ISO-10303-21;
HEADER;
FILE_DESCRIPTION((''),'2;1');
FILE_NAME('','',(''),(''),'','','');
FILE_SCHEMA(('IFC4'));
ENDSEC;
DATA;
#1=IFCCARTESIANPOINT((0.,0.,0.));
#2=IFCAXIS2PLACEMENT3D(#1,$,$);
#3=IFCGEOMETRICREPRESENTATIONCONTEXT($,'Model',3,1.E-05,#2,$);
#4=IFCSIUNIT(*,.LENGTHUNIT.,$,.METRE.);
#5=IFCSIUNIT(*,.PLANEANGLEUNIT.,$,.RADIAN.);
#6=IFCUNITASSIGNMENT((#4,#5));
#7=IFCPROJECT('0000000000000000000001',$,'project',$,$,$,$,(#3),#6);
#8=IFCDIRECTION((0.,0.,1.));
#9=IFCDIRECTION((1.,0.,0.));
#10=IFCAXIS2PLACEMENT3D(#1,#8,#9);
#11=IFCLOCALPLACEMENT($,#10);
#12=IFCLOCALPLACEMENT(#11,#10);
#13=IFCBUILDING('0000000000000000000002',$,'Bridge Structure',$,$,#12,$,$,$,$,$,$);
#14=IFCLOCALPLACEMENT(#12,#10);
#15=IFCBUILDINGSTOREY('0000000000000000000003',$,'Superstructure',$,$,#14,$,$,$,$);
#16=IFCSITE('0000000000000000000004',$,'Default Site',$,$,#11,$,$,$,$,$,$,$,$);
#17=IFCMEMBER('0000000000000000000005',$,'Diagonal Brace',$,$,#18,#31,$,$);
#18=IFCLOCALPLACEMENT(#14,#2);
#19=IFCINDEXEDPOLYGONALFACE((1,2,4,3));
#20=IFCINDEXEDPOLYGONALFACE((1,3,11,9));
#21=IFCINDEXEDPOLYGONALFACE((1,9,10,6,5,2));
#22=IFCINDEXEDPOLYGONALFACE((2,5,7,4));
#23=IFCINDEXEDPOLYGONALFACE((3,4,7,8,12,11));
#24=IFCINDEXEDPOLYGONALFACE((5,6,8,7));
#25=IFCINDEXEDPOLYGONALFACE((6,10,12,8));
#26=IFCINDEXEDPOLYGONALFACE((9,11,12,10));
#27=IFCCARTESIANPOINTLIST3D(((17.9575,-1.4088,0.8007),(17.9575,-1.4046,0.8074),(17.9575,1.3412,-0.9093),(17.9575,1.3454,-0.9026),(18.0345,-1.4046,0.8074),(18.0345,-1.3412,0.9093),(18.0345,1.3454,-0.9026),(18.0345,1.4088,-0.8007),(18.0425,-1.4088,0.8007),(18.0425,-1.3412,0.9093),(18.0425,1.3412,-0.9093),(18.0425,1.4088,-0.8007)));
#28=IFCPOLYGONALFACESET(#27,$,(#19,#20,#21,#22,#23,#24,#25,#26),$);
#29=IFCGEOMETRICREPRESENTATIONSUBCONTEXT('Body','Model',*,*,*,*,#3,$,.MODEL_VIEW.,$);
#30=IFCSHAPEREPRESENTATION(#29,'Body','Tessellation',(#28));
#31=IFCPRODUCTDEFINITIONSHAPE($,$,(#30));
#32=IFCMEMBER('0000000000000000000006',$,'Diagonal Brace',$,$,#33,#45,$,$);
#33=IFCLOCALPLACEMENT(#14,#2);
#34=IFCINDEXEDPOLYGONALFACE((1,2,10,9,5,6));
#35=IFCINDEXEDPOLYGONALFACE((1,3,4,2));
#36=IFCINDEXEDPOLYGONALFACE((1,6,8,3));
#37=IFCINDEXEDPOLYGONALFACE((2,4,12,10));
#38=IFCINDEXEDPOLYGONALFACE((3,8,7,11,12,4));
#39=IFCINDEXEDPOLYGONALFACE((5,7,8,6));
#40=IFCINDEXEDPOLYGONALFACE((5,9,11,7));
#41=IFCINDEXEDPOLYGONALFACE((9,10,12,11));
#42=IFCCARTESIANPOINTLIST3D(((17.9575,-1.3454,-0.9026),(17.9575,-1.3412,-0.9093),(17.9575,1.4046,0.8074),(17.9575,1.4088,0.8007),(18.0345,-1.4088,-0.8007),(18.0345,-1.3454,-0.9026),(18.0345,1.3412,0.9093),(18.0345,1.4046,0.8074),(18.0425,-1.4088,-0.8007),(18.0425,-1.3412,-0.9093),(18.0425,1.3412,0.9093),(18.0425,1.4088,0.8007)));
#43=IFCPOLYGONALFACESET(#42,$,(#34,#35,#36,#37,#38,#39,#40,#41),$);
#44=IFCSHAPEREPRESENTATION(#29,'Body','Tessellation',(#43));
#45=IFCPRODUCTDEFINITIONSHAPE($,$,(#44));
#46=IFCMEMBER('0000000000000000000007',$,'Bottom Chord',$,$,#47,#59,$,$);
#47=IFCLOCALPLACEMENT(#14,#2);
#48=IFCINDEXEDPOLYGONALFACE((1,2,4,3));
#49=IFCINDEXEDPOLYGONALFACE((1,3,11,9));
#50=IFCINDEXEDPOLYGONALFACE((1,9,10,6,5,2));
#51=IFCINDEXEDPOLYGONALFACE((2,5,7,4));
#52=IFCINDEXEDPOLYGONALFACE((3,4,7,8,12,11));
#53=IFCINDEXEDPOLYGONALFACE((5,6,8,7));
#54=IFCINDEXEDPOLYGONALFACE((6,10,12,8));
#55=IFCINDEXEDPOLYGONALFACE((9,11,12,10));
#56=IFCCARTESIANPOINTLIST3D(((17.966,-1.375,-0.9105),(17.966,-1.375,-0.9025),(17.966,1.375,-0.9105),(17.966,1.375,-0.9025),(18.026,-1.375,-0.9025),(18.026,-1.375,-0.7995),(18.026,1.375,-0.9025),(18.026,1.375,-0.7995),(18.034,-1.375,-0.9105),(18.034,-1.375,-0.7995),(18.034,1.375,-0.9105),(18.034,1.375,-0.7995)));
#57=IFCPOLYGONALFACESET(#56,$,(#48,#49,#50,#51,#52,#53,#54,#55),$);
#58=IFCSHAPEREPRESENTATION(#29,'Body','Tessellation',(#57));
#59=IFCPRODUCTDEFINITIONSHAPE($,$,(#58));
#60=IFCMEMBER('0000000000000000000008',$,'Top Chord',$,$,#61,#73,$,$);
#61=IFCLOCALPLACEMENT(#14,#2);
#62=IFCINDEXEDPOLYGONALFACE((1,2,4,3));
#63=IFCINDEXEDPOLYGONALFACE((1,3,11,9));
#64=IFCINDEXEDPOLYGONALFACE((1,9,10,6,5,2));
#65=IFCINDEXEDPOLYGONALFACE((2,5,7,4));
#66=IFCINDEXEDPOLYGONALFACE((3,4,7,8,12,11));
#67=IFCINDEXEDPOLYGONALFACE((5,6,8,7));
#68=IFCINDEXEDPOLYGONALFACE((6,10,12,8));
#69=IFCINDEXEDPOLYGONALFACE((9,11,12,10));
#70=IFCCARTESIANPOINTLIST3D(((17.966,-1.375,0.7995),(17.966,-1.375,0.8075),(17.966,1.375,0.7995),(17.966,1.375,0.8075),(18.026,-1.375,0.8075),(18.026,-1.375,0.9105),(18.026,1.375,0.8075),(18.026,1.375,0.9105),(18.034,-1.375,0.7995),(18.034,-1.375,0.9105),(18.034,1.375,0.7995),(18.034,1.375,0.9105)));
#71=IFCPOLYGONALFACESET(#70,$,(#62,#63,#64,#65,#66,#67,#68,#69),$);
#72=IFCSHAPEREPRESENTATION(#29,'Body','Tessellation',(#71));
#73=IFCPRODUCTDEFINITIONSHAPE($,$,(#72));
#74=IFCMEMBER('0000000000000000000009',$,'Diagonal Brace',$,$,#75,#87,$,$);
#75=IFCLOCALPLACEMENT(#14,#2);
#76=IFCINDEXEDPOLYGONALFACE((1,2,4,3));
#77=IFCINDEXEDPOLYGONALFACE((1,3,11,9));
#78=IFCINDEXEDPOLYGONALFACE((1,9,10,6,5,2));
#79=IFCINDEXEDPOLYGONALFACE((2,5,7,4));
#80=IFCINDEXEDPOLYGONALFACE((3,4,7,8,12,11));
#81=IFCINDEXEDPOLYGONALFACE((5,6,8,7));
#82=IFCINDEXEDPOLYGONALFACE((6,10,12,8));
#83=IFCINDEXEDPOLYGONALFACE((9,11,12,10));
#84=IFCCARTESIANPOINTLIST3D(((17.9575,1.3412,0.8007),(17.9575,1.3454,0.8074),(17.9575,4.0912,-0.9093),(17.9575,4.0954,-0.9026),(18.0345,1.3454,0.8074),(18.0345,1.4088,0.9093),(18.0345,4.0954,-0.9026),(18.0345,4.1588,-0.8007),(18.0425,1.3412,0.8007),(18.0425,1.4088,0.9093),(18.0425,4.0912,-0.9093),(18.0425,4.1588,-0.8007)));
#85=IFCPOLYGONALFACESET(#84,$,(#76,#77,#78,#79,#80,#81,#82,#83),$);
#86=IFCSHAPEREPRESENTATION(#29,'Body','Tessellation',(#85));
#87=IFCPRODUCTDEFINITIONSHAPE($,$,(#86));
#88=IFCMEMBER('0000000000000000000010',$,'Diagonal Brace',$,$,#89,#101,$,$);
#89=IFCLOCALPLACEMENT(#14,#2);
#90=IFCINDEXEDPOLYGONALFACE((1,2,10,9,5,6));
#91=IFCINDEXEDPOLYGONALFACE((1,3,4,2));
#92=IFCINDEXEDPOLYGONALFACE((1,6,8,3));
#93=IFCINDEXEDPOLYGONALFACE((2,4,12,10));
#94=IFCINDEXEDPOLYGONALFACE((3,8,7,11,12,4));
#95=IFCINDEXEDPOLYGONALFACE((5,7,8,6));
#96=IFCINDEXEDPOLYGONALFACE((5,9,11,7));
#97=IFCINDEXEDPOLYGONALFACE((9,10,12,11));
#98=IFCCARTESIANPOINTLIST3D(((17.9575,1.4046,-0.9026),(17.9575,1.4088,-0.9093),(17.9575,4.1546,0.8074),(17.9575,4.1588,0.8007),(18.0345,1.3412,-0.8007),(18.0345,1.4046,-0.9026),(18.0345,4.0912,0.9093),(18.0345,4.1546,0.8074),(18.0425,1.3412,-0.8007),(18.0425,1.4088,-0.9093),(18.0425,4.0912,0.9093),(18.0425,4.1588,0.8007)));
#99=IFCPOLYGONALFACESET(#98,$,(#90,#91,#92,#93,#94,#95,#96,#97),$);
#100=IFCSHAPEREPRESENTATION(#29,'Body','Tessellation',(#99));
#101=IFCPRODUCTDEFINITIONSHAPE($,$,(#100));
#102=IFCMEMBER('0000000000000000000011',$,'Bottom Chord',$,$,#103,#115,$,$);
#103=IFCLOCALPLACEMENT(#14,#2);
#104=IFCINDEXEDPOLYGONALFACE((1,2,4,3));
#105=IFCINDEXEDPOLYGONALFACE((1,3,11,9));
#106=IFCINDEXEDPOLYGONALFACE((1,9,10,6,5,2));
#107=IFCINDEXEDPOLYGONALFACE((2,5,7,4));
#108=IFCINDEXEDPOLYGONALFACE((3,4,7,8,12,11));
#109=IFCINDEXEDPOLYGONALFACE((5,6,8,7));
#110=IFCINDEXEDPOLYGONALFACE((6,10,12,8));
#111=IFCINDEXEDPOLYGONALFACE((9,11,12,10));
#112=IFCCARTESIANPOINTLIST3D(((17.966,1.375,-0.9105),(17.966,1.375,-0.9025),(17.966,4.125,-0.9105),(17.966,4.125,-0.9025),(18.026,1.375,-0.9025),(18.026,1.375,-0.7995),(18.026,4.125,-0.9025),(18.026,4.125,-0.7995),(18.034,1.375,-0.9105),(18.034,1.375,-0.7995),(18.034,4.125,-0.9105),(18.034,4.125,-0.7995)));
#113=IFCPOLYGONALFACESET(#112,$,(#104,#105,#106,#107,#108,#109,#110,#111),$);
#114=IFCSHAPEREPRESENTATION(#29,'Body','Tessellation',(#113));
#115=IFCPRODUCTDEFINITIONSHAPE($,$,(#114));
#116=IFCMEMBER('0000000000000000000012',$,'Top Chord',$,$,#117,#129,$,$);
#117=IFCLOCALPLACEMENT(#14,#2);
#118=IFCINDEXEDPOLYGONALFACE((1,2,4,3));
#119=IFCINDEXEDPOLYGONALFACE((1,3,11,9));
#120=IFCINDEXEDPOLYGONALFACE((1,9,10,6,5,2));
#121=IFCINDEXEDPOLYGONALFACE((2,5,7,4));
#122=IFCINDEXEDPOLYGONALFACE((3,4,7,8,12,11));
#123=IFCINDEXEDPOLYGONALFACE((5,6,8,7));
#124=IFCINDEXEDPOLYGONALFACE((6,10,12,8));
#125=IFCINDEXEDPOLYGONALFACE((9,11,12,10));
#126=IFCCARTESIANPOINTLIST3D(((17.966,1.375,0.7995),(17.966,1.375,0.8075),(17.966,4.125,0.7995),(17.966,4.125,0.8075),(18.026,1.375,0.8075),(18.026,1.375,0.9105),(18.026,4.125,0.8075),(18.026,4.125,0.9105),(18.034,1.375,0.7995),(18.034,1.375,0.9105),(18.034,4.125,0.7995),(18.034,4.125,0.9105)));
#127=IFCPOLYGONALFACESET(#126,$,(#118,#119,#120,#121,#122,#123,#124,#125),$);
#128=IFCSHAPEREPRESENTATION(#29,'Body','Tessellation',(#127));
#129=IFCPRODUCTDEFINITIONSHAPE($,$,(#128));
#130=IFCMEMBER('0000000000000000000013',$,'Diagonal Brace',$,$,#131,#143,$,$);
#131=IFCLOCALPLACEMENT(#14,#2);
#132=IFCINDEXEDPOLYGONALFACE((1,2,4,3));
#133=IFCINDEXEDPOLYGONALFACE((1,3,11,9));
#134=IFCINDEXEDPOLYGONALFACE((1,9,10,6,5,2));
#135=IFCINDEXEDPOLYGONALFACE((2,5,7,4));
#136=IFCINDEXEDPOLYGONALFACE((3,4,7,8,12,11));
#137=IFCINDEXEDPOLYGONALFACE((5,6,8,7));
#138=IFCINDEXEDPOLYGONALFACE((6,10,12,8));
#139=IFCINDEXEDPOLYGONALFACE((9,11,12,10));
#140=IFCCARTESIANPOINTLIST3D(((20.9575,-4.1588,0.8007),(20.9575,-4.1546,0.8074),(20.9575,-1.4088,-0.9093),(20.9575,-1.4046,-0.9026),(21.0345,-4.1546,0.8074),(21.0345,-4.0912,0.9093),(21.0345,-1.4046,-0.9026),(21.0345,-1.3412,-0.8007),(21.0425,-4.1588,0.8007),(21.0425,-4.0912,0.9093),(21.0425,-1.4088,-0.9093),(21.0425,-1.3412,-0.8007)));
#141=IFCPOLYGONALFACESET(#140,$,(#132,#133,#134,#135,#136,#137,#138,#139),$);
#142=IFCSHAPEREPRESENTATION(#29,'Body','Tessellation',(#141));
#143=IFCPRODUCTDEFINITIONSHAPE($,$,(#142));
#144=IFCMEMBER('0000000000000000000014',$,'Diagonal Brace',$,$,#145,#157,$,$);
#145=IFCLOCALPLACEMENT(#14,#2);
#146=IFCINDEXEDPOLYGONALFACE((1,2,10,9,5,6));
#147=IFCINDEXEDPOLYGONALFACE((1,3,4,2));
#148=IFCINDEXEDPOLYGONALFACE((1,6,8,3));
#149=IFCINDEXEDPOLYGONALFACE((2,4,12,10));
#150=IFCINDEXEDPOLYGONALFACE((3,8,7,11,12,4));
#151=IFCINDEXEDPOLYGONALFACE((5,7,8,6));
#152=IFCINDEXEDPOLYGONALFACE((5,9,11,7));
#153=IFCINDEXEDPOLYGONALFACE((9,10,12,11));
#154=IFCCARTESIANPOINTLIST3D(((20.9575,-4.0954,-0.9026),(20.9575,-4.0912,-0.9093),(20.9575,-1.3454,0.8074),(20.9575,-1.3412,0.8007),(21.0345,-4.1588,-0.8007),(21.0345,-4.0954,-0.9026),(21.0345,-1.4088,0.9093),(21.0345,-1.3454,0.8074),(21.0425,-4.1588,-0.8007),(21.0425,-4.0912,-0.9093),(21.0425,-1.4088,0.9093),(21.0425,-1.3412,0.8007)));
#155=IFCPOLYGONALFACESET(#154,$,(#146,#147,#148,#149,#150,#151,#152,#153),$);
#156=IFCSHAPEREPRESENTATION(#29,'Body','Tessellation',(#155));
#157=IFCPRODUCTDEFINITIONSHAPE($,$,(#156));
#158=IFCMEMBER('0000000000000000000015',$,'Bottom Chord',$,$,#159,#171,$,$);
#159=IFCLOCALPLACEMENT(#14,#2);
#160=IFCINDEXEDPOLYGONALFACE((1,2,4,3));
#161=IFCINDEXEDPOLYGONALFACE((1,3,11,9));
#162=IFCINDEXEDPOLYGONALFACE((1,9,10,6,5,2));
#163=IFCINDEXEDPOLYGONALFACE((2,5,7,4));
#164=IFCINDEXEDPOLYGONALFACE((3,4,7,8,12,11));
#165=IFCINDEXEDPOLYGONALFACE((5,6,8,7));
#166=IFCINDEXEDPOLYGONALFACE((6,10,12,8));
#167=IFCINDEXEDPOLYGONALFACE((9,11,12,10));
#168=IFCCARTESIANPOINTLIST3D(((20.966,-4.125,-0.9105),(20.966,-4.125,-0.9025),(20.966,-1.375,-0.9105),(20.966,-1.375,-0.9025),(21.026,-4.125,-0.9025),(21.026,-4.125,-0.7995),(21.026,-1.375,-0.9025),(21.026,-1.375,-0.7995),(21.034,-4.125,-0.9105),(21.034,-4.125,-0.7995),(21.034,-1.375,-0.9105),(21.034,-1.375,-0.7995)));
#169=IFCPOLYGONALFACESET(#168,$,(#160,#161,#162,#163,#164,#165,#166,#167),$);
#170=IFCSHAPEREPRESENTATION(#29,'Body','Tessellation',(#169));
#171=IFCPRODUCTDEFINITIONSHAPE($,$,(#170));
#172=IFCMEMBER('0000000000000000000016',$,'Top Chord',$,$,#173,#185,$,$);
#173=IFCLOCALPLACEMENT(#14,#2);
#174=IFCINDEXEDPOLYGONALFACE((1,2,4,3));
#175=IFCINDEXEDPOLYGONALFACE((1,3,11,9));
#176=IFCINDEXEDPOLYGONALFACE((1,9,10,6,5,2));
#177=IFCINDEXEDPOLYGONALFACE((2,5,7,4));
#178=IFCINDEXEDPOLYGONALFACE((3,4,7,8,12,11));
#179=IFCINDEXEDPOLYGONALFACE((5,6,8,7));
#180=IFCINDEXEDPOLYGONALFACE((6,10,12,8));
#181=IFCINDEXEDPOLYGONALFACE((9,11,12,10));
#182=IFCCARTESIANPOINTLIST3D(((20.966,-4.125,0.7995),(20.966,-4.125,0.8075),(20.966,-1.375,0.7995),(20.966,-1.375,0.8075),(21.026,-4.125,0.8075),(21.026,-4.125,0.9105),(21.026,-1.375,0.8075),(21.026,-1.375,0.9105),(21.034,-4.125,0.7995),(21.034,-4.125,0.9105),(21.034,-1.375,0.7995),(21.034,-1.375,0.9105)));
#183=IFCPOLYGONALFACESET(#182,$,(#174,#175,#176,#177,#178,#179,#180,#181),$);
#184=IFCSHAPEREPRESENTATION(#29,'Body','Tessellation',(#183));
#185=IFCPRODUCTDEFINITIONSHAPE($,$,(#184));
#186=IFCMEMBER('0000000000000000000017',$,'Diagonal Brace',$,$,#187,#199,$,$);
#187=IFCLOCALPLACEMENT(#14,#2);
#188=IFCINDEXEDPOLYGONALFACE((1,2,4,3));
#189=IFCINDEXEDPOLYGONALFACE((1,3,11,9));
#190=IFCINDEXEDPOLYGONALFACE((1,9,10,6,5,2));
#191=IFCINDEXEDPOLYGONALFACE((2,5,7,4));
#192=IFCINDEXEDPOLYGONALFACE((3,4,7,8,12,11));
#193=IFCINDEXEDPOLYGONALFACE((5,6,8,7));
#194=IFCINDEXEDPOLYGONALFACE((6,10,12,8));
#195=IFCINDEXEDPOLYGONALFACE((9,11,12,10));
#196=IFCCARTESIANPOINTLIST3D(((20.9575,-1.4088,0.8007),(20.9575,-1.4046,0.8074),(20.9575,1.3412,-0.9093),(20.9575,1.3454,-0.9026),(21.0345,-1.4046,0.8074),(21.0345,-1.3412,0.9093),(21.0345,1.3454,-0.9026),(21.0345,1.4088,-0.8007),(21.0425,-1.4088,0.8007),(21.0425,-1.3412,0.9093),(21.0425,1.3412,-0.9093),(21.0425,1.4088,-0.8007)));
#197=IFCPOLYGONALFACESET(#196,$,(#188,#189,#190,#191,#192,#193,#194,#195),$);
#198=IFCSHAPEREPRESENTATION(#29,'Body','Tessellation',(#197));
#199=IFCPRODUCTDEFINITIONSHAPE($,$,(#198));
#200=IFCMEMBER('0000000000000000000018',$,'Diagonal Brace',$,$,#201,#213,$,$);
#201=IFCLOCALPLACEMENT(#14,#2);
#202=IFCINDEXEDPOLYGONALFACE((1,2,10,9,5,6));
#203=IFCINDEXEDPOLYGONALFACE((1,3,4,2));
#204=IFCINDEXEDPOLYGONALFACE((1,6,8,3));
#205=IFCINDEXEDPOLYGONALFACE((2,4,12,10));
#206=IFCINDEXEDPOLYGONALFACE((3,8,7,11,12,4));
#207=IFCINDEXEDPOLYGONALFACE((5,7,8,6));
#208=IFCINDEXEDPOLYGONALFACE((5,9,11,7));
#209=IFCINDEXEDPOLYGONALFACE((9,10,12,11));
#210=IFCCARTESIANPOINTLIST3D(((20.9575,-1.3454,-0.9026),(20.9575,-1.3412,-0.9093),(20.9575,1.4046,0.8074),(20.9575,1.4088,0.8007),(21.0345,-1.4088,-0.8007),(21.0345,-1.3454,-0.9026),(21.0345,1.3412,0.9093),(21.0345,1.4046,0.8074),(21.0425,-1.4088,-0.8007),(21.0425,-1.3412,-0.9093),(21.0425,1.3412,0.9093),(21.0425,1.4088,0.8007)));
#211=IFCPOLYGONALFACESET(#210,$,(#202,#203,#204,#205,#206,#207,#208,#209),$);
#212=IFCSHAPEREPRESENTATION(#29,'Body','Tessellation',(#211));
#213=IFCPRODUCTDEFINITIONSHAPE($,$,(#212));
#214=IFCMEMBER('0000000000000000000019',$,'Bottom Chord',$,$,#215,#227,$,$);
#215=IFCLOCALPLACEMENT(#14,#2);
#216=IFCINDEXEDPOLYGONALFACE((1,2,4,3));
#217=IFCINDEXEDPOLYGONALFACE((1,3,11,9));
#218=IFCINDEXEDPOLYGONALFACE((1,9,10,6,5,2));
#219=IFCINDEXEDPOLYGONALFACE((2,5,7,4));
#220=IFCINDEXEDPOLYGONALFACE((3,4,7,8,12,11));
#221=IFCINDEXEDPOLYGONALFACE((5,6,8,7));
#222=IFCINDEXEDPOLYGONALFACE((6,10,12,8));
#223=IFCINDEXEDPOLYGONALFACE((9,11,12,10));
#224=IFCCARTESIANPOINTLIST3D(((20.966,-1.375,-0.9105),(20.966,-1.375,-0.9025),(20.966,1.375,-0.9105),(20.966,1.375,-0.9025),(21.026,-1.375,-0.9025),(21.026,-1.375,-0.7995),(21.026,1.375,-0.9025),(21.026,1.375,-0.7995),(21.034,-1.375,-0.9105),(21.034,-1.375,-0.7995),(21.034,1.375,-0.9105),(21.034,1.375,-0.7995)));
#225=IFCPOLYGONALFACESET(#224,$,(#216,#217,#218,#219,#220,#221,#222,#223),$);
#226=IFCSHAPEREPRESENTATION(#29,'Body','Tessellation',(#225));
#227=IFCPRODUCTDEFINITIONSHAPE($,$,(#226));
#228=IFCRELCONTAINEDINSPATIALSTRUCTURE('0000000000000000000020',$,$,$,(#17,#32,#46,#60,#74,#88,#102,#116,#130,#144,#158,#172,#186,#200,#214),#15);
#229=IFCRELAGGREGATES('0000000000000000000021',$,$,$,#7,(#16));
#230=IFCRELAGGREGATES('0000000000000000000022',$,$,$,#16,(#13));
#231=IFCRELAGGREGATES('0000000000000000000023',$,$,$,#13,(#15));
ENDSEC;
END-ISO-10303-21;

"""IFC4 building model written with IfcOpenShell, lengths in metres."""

from ifc_helpers import new_model, si_unit, frame, origin, origin_with_axes, origin_2d_with_axis, place, context, subcontext, project, spatial, l_section, extrude, element, save


model = new_model("IFC4")

# Units and contexts
model_context = context("Model", 3, precision=1e-05, world=origin())
body_context = subcontext(model_context, "Body", "Model", "MODEL_VIEW")
ifc_project = project(units=[si_unit("LENGTHUNIT", "METRE"), si_unit("PLANEANGLEUNIT", "RADIAN")], contexts=[model_context])

# Site, building, storey
site_placement = place(None, origin_with_axes())
site = spatial("IfcSite", under=ifc_project, at=site_placement, Name="Default Site")
building_placement = place(site_placement, origin_with_axes())
building = spatial("IfcBuilding", under=site, at=building_placement, Name="Bridge Structure")
storey_placement = place(building_placement, origin_with_axes())
storey = spatial("IfcBuildingStorey", under=building, at=storey_placement, Name="Superstructure")

# Members
for number, where, z_axis, x_axis, name in (
    (1, (18.0, -1.375, 0.855), (0.0, 0.84921, -0.528055), (-1.0, 0.0, 0.0), "Diagonal Brace"),
    (2, (18.0, -1.375, -0.855), (0.0, 0.84921, 0.528055), (-1.0, 0.0, 0.0), "Diagonal Brace"),
):
    element("IfcMember", number, at=place(storey_placement, frame(where, z_axis=z_axis, x_axis=x_axis)), inside=storey, Name=name, context=body_context, shape_type="SweptSolid", body=[
        extrude(l_section(Depth=0.128, Width=0.085, Thickness=0.008, at=origin_2d_with_axis()), origin_with_axes(), (0.0, 0.0, 1.0), 3.2383),
    ])
for number, where, z_axis, x_axis, name in (
    (3, (18.0, -1.375, -0.855), (0.0, 1.0, 0.0), (-1.0, 0.0, 0.0), "Bottom Chord"),
    (4, (18.0, -1.375, 0.855), (0.0, 1.0, 0.0), (-1.0, 0.0, 0.0), "Top Chord"),
):
    element("IfcMember", number, at=place(storey_placement, frame(where, z_axis=z_axis, x_axis=x_axis)), inside=storey, Name=name, context=body_context, shape_type="SweptSolid", body=[
        extrude(l_section(Depth=0.111, Width=0.068, Thickness=0.008, at=origin_2d_with_axis()), origin_with_axes(), (0.0, 0.0, 1.0), 2.75),
    ])
for number, where, z_axis, x_axis, name in (
    (5, (18.0, 1.375, 0.855), (0.0, 0.84921, -0.528055), (-1.0, 0.0, 0.0), "Diagonal Brace"),
    (6, (18.0, 1.375, -0.855), (0.0, 0.84921, 0.528055), (-1.0, 0.0, 0.0), "Diagonal Brace"),
):
    element("IfcMember", number, at=place(storey_placement, frame(where, z_axis=z_axis, x_axis=x_axis)), inside=storey, Name=name, context=body_context, shape_type="SweptSolid", body=[
        extrude(l_section(Depth=0.128, Width=0.085, Thickness=0.008, at=origin_2d_with_axis()), origin_with_axes(), (0.0, 0.0, 1.0), 3.2383),
    ])
for number, where, z_axis, x_axis, name in (
    (7, (18.0, 1.375, -0.855), (0.0, 1.0, 0.0), (-1.0, 0.0, 0.0), "Bottom Chord"),
    (8, (18.0, 1.375, 0.855), (0.0, 1.0, 0.0), (-1.0, 0.0, 0.0), "Top Chord"),
):
    element("IfcMember", number, at=place(storey_placement, frame(where, z_axis=z_axis, x_axis=x_axis)), inside=storey, Name=name, context=body_context, shape_type="SweptSolid", body=[
        extrude(l_section(Depth=0.111, Width=0.068, Thickness=0.008, at=origin_2d_with_axis()), origin_with_axes(), (0.0, 0.0, 1.0), 2.75),
    ])
for number, where, z_axis, x_axis, name in (
    (9, (21.0, -4.125, 0.855), (0.0, 0.84921, -0.528055), (-1.0, 0.0, 0.0), "Diagonal Brace"),
    (10, (21.0, -4.125, -0.855), (0.0, 0.84921, 0.528055), (-1.0, 0.0, 0.0), "Diagonal Brace"),
):
    element("IfcMember", number, at=place(storey_placement, frame(where, z_axis=z_axis, x_axis=x_axis)), inside=storey, Name=name, context=body_context, shape_type="SweptSolid", body=[
        extrude(l_section(Depth=0.128, Width=0.085, Thickness=0.008, at=origin_2d_with_axis()), origin_with_axes(), (0.0, 0.0, 1.0), 3.2383),
    ])
for number, where, z_axis, x_axis, name in (
    (11, (21.0, -4.125, -0.855), (0.0, 1.0, 0.0), (-1.0, 0.0, 0.0), "Bottom Chord"),
    (12, (21.0, -4.125, 0.855), (0.0, 1.0, 0.0), (-1.0, 0.0, 0.0), "Top Chord"),
):
    element("IfcMember", number, at=place(storey_placement, frame(where, z_axis=z_axis, x_axis=x_axis)), inside=storey, Name=name, context=body_context, shape_type="SweptSolid", body=[
        extrude(l_section(Depth=0.111, Width=0.068, Thickness=0.008, at=origin_2d_with_axis()), origin_with_axes(), (0.0, 0.0, 1.0), 2.75),
    ])
for number, where, z_axis, x_axis, name in (
    (13, (21.0, -1.375, 0.855), (0.0, 0.84921, -0.528055), (-1.0, 0.0, 0.0), "Diagonal Brace"),
    (14, (21.0, -1.375, -0.855), (0.0, 0.84921, 0.528055), (-1.0, 0.0, 0.0), "Diagonal Brace"),
):
    element("IfcMember", number, at=place(storey_placement, frame(where, z_axis=z_axis, x_axis=x_axis)), inside=storey, Name=name, context=body_context, shape_type="SweptSolid", body=[
        extrude(l_section(Depth=0.128, Width=0.085, Thickness=0.008, at=origin_2d_with_axis()), origin_with_axes(), (0.0, 0.0, 1.0), 3.2383),
    ])
for number, where, z_axis, x_axis, name in (
    (15, (21.0, -1.375, -0.855), (0.0, 1.0, 0.0), (-1.0, 0.0, 0.0), "Bottom Chord"),
):
    element("IfcMember", number, at=place(storey_placement, frame(where, z_axis=z_axis, x_axis=x_axis)), inside=storey, Name=name, context=body_context, shape_type="SweptSolid", body=[
        extrude(l_section(Depth=0.111, Width=0.068, Thickness=0.008, at=origin_2d_with_axis()), origin_with_axes(), (0.0, 0.0, 1.0), 2.75),
    ])

save(model, "model.ifc")
